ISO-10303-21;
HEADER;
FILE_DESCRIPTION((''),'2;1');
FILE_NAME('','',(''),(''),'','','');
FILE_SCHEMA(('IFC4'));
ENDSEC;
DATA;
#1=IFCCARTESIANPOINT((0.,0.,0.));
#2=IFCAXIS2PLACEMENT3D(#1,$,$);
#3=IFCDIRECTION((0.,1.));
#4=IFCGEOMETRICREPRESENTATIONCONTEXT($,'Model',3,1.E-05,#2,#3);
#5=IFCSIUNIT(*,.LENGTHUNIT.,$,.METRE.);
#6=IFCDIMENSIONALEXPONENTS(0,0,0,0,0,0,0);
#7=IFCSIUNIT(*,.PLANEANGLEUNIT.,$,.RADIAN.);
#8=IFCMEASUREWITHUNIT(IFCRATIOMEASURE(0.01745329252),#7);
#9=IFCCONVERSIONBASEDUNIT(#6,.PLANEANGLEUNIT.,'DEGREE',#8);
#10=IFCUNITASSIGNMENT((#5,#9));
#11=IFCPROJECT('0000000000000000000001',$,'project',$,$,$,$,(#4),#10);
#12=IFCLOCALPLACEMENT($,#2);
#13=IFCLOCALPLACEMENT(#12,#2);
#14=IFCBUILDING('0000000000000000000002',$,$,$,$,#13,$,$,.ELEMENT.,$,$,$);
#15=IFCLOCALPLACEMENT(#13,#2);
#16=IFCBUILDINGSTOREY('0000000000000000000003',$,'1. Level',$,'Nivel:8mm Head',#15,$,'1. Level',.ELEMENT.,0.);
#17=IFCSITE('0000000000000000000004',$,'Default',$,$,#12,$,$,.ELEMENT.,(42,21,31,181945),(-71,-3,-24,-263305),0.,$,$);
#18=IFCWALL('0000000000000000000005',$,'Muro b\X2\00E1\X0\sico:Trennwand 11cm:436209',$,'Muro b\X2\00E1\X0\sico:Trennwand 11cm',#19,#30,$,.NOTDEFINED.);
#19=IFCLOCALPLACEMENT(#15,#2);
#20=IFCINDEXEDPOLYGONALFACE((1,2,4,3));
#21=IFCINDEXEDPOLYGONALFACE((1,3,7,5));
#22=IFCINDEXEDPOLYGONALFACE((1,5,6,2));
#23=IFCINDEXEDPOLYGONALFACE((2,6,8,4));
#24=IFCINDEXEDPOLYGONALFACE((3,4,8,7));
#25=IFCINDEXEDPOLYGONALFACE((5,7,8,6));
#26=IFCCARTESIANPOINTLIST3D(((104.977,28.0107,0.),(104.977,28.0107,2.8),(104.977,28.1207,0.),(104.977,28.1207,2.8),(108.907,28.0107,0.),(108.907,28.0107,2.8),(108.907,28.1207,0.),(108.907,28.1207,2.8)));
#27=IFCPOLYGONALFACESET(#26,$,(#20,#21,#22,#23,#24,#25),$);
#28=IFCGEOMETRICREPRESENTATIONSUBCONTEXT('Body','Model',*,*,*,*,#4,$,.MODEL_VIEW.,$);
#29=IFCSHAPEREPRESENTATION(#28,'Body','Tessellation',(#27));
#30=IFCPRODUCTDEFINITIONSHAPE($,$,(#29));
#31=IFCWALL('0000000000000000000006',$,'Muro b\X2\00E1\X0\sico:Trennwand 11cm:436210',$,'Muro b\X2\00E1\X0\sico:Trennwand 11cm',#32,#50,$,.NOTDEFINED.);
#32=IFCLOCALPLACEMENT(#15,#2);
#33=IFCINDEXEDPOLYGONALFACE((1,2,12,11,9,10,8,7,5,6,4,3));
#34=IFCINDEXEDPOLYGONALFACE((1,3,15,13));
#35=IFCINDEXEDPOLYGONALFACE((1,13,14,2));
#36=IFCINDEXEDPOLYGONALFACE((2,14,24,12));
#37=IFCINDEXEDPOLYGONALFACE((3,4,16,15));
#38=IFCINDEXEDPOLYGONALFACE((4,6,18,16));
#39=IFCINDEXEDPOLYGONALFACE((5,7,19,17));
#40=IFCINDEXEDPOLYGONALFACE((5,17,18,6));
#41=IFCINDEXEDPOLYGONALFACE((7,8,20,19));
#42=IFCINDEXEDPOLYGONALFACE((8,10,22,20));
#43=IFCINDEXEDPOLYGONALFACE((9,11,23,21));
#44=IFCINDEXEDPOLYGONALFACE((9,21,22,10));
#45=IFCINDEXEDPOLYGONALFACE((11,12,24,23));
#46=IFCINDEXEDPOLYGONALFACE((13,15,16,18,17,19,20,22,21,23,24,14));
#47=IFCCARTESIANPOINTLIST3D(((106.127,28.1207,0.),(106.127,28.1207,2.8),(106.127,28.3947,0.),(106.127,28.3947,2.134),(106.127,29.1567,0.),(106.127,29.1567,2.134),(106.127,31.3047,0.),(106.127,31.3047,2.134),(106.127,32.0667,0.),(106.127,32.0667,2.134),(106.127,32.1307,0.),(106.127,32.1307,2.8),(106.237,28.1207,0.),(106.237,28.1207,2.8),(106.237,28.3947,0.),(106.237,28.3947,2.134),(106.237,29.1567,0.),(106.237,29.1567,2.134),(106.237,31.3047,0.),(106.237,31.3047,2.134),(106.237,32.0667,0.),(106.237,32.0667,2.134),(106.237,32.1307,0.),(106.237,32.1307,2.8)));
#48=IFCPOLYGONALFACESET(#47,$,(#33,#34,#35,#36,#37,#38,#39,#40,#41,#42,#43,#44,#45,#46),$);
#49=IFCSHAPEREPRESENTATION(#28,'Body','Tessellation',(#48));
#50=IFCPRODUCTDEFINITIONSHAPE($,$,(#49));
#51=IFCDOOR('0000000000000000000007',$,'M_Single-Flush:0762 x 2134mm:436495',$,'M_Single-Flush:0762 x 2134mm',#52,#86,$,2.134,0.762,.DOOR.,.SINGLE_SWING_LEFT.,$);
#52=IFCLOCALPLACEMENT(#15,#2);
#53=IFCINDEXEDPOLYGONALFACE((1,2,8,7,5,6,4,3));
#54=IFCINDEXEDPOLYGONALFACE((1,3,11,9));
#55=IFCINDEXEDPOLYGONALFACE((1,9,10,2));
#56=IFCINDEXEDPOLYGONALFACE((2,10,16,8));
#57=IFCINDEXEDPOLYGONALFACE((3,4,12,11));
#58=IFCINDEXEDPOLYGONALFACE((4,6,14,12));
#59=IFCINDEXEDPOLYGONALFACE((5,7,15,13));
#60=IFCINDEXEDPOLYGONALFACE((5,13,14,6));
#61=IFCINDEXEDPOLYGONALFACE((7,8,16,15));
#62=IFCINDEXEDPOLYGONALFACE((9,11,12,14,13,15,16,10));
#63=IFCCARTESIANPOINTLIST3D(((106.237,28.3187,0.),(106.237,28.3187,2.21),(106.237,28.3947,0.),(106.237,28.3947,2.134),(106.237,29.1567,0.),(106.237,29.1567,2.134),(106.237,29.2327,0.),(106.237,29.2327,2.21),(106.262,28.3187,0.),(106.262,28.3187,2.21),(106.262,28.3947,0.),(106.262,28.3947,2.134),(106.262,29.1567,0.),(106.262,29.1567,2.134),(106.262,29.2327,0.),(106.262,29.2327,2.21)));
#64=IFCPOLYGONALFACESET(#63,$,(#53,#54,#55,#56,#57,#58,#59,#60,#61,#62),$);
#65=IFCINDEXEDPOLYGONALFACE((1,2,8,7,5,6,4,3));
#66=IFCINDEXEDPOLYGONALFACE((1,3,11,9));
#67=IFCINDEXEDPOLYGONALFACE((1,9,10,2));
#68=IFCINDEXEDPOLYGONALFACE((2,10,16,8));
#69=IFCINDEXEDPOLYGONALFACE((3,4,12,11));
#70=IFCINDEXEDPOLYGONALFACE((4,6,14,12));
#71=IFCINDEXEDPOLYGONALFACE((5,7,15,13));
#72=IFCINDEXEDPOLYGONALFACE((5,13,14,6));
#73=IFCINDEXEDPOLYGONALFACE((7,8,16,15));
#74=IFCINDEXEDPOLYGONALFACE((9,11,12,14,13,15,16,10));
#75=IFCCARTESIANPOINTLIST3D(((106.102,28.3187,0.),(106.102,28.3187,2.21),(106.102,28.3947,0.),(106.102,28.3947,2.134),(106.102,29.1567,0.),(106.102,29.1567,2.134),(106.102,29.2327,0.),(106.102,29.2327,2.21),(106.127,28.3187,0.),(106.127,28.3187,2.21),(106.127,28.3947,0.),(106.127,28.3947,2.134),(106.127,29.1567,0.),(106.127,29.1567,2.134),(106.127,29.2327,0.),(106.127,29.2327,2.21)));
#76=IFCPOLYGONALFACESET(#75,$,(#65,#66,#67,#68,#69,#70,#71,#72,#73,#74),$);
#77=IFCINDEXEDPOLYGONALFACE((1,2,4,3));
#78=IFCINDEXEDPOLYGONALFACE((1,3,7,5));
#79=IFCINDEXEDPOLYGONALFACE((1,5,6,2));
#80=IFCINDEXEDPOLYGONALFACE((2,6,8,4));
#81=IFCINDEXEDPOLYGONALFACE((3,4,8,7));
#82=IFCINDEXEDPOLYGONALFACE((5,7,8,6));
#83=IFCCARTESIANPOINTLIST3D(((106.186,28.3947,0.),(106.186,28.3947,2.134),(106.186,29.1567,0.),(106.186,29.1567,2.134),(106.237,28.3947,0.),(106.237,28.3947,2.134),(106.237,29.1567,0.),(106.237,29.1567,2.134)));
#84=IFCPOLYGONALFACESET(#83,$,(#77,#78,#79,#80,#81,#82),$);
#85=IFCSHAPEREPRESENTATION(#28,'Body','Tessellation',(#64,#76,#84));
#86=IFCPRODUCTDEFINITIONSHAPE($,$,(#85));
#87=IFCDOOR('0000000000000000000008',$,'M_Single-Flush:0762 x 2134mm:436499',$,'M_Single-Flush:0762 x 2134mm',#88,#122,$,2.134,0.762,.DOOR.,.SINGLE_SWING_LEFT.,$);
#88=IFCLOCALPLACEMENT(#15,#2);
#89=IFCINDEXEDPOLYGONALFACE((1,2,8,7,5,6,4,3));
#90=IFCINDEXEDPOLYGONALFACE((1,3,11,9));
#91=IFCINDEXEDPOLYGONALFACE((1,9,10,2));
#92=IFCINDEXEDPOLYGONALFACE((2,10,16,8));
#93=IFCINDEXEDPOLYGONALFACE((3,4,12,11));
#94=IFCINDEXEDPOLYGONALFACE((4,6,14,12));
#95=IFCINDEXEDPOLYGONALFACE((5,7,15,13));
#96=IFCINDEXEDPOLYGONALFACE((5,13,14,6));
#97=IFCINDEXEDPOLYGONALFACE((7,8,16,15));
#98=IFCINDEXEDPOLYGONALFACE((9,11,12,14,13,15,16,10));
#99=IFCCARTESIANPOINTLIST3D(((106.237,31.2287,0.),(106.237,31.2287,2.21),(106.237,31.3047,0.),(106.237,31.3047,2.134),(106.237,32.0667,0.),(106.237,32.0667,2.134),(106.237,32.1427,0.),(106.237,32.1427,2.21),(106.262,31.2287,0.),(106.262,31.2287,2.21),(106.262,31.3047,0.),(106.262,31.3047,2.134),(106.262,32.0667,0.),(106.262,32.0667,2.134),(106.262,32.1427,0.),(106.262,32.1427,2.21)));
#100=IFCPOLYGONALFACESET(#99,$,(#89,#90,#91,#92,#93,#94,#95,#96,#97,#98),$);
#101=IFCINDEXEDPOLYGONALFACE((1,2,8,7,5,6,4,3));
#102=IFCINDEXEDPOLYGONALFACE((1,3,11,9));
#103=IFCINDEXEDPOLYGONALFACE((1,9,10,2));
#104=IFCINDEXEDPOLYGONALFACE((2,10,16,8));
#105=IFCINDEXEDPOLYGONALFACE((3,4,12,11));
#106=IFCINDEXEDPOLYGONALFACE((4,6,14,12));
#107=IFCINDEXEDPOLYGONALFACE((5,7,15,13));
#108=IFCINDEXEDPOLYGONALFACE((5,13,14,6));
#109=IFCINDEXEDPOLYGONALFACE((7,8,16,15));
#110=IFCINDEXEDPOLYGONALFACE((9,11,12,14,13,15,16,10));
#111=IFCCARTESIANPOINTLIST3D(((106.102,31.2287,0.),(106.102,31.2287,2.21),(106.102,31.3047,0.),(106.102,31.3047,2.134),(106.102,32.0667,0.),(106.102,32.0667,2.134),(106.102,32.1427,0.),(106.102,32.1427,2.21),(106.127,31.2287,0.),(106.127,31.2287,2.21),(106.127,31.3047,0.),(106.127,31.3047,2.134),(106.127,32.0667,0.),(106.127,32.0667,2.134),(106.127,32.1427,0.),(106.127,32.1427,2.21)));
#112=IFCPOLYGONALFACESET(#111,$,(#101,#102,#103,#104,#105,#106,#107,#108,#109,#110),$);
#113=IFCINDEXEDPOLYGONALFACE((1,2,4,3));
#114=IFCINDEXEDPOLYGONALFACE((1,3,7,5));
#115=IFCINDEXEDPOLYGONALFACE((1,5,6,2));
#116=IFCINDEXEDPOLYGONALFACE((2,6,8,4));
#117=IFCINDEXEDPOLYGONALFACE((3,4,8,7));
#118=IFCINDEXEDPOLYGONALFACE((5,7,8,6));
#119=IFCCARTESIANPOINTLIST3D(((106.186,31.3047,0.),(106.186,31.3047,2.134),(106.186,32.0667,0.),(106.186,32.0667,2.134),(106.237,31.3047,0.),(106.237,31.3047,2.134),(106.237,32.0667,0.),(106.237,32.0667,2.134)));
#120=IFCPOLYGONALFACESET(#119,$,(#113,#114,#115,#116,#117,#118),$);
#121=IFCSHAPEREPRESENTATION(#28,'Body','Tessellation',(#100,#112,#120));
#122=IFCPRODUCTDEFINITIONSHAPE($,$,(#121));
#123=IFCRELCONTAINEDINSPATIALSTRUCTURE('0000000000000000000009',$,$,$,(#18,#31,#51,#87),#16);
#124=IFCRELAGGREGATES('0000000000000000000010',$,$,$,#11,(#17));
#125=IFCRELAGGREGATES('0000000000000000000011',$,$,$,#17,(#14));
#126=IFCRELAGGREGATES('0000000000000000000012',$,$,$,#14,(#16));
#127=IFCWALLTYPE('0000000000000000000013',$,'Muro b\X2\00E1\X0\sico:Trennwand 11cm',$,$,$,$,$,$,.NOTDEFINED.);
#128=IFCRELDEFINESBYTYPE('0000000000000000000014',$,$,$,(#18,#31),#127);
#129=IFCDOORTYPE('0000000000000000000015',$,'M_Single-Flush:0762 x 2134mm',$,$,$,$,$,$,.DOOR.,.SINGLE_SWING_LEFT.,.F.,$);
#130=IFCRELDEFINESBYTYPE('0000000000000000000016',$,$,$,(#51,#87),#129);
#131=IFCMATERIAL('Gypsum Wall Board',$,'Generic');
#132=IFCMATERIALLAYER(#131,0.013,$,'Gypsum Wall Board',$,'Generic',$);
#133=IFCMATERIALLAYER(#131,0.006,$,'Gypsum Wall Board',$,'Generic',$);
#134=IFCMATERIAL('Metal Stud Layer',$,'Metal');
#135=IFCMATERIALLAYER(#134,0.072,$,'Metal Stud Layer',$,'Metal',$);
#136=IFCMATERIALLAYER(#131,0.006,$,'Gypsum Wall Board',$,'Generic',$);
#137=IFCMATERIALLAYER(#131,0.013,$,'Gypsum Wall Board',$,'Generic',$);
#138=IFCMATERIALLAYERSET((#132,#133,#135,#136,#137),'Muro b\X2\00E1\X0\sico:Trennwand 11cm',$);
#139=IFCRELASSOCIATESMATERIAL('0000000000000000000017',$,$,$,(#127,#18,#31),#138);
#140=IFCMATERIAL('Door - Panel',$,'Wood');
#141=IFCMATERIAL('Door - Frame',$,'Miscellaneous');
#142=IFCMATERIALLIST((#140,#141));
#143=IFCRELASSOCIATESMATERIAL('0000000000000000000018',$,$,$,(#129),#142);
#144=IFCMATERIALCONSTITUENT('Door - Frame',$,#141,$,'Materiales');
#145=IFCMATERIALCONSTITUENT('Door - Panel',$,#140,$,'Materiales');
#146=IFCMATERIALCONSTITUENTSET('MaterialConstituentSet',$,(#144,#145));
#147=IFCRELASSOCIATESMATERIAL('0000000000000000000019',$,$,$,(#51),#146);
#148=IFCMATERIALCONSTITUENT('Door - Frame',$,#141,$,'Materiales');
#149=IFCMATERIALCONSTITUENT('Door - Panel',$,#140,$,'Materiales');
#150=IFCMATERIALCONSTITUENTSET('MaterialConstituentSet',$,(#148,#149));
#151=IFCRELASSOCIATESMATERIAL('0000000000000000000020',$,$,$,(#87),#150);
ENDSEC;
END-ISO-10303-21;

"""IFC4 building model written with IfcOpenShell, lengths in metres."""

from ifc_helpers import new_model, entity, si_unit, converted_unit, direction, frame, frame_2d, origin, origin_2d_with_axis, place, context, subcontext, project, spatial, polyline, rectangle, outline, extrude, source, transform, mapped, material, material_list, layer, layer_set, layer_usage, constituent, constituent_set, type_object, type_shapes, element, fill, save


model = new_model("IFC4")

# Units and contexts
model_context = context("Model", 3, precision=1e-05, world=origin(), true_north=direction((0.0, 1.0)))
body_context = subcontext(model_context, "Body", "Model", "MODEL_VIEW")
ifc_project = project(units=[si_unit("LENGTHUNIT", "METRE"), converted_unit("PLANEANGLEUNIT", "DEGREE", entity("IfcRatioMeasure", 0.01745329252), si_unit("PLANEANGLEUNIT", "RADIAN"), dimensions=[0, 0, 0, 0, 0, 0, 0])], contexts=[model_context])

# Site, building, storey
site_placement = place(None, origin())
site = spatial("IfcSite", under=ifc_project, at=site_placement, Name="Default", CompositionType="ELEMENT", RefLatitude=(42, 21, 31, 181945), RefLongitude=(-71, -3, -24, -263305), RefElevation=0.0)
building_placement = place(site_placement, origin())
building = spatial("IfcBuilding", under=site, at=building_placement, CompositionType="ELEMENT")
storey_placement = place(building_placement, origin())
storey = spatial("IfcBuildingStorey", under=building, at=storey_placement, Name="1. Level", ObjectType="Nivel:8mm Head", LongName="1. Level", CompositionType="ELEMENT", Elevation=0.0)

# Shared definitions
ifc_material_1 = material(Name="Gypsum Wall Board", Category="Generic")
ifc_layer_1 = layer(ifc_material_1, 0.013, Name="Gypsum Wall Board", Category="Generic")
ifc_layer_2 = layer(ifc_material_1, 0.006, Name="Gypsum Wall Board", Category="Generic")
ifc_material_2 = material(Name="Metal Stud Layer", Category="Metal")
ifc_layer_3 = layer(ifc_material_2, 0.072, Name="Metal Stud Layer", Category="Metal")
ifc_layer_4 = layer(ifc_material_1, 0.006, Name="Gypsum Wall Board", Category="Generic")
ifc_layer_5 = layer(ifc_material_1, 0.013, Name="Gypsum Wall Board", Category="Generic")
ifc_layer_set_1 = layer_set([ifc_layer_1, ifc_layer_2, ifc_layer_3, ifc_layer_4, ifc_layer_5], Name="Muro básico:Trennwand 11cm")
wall_type_1 = type_object("IfcWallType", Name="Muro básico:Trennwand 11cm", PredefinedType="NOTDEFINED", material=ifc_layer_set_1)
ifc_material_3 = material(Name="Door - Frame", Category="Miscellaneous")
ifc_material_4 = material(Name="Door - Panel", Category="Wood")
ifc_material_list_1 = material_list([ifc_material_4, ifc_material_3])
door_type_1 = type_object("IfcDoorType", Name="M_Single-Flush:0762 x 2134mm", OperationType="SINGLE_SWING_LEFT", ParameterTakesPrecedence=False, PredefinedType="DOOR", material=ifc_material_list_1)
shared_shape_1 = source(origin(), body_context, "Body", "SweptSolid", [
    extrude(outline(polyline([(-0.457, -1.124), (0.457, -1.124), (0.457, 1.086), (0.381, 1.086), (0.381, -1.048), (-0.381, -1.048), (-0.381, 1.086), (-0.457, 1.086), (-0.457, -1.124)])), frame((0.381, 0.135, 1.086), z_axis=(0.0, -1.0, 0.0), x_axis=(-1.0, 0.0, 0.0)), (0.0, 0.0, 1.0), 0.025),
    extrude(outline(polyline([(-1.124, -0.457), (1.086, -0.457), (1.086, -0.381), (-1.048, -0.381), (-1.048, 0.381), (1.086, 0.381), (1.086, 0.457), (-1.124, 0.457), (-1.124, -0.457)])), frame((0.381, 0.0, 1.086), z_axis=(0.0, -1.0, 0.0), x_axis=(0.0, 0.0, -1.0)), (0.0, 0.0, 1.0), 0.025),
    extrude(rectangle(XDim=0.762, YDim=0.051, at=origin_2d_with_axis()), frame((0.381, 0.0845, 0.0)), (0.0, 0.0, 1.0), 2.134),
])
type_shapes(door_type_1, [shared_shape_1])

# Wall
ifc_layer_usage_1 = layer_usage(ifc_layer_set_1, "AXIS2", "NEGATIVE", 0.055)
wall_1_placement = place(storey_placement, frame((104.977, 28.0657, 0.0)))
element("IfcWall", 1, at=wall_1_placement, inside=storey, type_object=wall_type_1, material=ifc_layer_usage_1, Name="Muro básico:Trennwand 11cm:436209", ObjectType="Muro básico:Trennwand 11cm", PredefinedType="NOTDEFINED", context=body_context, shape_type="SweptSolid", body=[
    extrude(rectangle(XDim=3.93, YDim=0.11, at=frame_2d((1.965, 0.0), x_axis=(-1.0, 0.0))), origin(), (0.0, 0.0, 1.0), 2.8),
])

# Wall, openings, doors
ifc_layer_usage_2 = layer_usage(ifc_layer_set_1, "AXIS2", "NEGATIVE", 0.055)
wall_2_placement = place(storey_placement, frame((106.182, 28.1207, 0.0), z_axis=(0.0, 0.0, 1.0), x_axis=(0.0, 1.0, 0.0)))
wall_2 = element("IfcWall", 2, at=wall_2_placement, inside=storey, type_object=wall_type_1, material=ifc_layer_usage_2, Name="Muro básico:Trennwand 11cm:436210", ObjectType="Muro básico:Trennwand 11cm", PredefinedType="NOTDEFINED", context=body_context, shape_type="SweptSolid", body=[
    extrude(rectangle(XDim=4.01, YDim=0.11, at=frame_2d((2.005, 0.0), x_axis=(-1.0, 0.0))), origin(), (0.0, 0.0, 1.0), 2.8),
])
opening_1_placement = place(wall_2_placement, frame((1.036, 0.055, 0.0)))
opening_1 = element("IfcOpeningElement", 3, at=opening_1_placement, cuts=wall_2, ObjectType="Opening", PredefinedType="OPENING", context=body_context, shape_type="SweptSolid", body=[
    extrude(rectangle(XDim=0.762, YDim=2.134, at=frame_2d((1.067, 0.381), x_axis=(0.0, -1.0))), frame((0.0, 0.0, 0.0), z_axis=(0.0, -1.0, 0.0), x_axis=(0.0, 0.0, 1.0)), (0.0, 0.0, 1.0), 0.11),
])
opening_2_placement = place(wall_2_placement, frame((3.946, 0.055, 0.0)))
opening_2 = element("IfcOpeningElement", 4, at=opening_2_placement, cuts=wall_2, ObjectType="Opening", PredefinedType="OPENING", context=body_context, shape_type="SweptSolid", body=[
    extrude(rectangle(XDim=0.762, YDim=2.134, at=frame_2d((1.067, 0.381), x_axis=(0.0, -1.0))), frame((0.0, 0.0, 0.0), z_axis=(0.0, -1.0, 0.0), x_axis=(0.0, 0.0, 1.0)), (0.0, 0.0, 1.0), 0.11),
])
ifc_constituent_1 = constituent(ifc_material_3, Name="Door - Frame", Category="Materiales")
ifc_constituent_2 = constituent(ifc_material_4, Name="Door - Panel", Category="Materiales")
ifc_constituent_set_1 = constituent_set(constituents=[ifc_constituent_1, ifc_constituent_2], Name="MaterialConstituentSet")
door_1_placement = place(opening_1_placement, frame((0.0, 0.0, 0.0), z_axis=(0.0, 0.0, 1.0), x_axis=(-1.0, 0.0, 0.0)))
door_1 = element("IfcDoor", 5, at=door_1_placement, inside=storey, type_object=door_type_1, material=ifc_constituent_set_1, Name="M_Single-Flush:0762 x 2134mm:436495", ObjectType="M_Single-Flush:0762 x 2134mm", OperationType="SINGLE_SWING_LEFT", OverallHeight=2.134, OverallWidth=0.762, PredefinedType="DOOR", context=body_context, shape_type="MappedRepresentation", body=[
    mapped(shared_shape_1, transform((0.0, 0.0, 0.0), scale=1.0)),
])
fill(opening_1, door_1)
ifc_constituent_3 = constituent(ifc_material_3, Name="Door - Frame", Category="Materiales")
ifc_constituent_4 = constituent(ifc_material_4, Name="Door - Panel", Category="Materiales")
ifc_constituent_set_2 = constituent_set(constituents=[ifc_constituent_3, ifc_constituent_4], Name="MaterialConstituentSet")
door_2_placement = place(opening_2_placement, frame((0.0, 0.0, 0.0), z_axis=(0.0, 0.0, 1.0), x_axis=(-1.0, 0.0, 0.0)))
door_2 = element("IfcDoor", 6, at=door_2_placement, inside=storey, type_object=door_type_1, material=ifc_constituent_set_2, Name="M_Single-Flush:0762 x 2134mm:436499", ObjectType="M_Single-Flush:0762 x 2134mm", OperationType="SINGLE_SWING_LEFT", OverallHeight=2.134, OverallWidth=0.762, PredefinedType="DOOR", context=body_context, shape_type="MappedRepresentation", body=[
    mapped(shared_shape_1, transform((0.0, 0.0, 0.0), scale=1.0)),
])
fill(opening_2, door_2)

save(model, "model.ifc")
